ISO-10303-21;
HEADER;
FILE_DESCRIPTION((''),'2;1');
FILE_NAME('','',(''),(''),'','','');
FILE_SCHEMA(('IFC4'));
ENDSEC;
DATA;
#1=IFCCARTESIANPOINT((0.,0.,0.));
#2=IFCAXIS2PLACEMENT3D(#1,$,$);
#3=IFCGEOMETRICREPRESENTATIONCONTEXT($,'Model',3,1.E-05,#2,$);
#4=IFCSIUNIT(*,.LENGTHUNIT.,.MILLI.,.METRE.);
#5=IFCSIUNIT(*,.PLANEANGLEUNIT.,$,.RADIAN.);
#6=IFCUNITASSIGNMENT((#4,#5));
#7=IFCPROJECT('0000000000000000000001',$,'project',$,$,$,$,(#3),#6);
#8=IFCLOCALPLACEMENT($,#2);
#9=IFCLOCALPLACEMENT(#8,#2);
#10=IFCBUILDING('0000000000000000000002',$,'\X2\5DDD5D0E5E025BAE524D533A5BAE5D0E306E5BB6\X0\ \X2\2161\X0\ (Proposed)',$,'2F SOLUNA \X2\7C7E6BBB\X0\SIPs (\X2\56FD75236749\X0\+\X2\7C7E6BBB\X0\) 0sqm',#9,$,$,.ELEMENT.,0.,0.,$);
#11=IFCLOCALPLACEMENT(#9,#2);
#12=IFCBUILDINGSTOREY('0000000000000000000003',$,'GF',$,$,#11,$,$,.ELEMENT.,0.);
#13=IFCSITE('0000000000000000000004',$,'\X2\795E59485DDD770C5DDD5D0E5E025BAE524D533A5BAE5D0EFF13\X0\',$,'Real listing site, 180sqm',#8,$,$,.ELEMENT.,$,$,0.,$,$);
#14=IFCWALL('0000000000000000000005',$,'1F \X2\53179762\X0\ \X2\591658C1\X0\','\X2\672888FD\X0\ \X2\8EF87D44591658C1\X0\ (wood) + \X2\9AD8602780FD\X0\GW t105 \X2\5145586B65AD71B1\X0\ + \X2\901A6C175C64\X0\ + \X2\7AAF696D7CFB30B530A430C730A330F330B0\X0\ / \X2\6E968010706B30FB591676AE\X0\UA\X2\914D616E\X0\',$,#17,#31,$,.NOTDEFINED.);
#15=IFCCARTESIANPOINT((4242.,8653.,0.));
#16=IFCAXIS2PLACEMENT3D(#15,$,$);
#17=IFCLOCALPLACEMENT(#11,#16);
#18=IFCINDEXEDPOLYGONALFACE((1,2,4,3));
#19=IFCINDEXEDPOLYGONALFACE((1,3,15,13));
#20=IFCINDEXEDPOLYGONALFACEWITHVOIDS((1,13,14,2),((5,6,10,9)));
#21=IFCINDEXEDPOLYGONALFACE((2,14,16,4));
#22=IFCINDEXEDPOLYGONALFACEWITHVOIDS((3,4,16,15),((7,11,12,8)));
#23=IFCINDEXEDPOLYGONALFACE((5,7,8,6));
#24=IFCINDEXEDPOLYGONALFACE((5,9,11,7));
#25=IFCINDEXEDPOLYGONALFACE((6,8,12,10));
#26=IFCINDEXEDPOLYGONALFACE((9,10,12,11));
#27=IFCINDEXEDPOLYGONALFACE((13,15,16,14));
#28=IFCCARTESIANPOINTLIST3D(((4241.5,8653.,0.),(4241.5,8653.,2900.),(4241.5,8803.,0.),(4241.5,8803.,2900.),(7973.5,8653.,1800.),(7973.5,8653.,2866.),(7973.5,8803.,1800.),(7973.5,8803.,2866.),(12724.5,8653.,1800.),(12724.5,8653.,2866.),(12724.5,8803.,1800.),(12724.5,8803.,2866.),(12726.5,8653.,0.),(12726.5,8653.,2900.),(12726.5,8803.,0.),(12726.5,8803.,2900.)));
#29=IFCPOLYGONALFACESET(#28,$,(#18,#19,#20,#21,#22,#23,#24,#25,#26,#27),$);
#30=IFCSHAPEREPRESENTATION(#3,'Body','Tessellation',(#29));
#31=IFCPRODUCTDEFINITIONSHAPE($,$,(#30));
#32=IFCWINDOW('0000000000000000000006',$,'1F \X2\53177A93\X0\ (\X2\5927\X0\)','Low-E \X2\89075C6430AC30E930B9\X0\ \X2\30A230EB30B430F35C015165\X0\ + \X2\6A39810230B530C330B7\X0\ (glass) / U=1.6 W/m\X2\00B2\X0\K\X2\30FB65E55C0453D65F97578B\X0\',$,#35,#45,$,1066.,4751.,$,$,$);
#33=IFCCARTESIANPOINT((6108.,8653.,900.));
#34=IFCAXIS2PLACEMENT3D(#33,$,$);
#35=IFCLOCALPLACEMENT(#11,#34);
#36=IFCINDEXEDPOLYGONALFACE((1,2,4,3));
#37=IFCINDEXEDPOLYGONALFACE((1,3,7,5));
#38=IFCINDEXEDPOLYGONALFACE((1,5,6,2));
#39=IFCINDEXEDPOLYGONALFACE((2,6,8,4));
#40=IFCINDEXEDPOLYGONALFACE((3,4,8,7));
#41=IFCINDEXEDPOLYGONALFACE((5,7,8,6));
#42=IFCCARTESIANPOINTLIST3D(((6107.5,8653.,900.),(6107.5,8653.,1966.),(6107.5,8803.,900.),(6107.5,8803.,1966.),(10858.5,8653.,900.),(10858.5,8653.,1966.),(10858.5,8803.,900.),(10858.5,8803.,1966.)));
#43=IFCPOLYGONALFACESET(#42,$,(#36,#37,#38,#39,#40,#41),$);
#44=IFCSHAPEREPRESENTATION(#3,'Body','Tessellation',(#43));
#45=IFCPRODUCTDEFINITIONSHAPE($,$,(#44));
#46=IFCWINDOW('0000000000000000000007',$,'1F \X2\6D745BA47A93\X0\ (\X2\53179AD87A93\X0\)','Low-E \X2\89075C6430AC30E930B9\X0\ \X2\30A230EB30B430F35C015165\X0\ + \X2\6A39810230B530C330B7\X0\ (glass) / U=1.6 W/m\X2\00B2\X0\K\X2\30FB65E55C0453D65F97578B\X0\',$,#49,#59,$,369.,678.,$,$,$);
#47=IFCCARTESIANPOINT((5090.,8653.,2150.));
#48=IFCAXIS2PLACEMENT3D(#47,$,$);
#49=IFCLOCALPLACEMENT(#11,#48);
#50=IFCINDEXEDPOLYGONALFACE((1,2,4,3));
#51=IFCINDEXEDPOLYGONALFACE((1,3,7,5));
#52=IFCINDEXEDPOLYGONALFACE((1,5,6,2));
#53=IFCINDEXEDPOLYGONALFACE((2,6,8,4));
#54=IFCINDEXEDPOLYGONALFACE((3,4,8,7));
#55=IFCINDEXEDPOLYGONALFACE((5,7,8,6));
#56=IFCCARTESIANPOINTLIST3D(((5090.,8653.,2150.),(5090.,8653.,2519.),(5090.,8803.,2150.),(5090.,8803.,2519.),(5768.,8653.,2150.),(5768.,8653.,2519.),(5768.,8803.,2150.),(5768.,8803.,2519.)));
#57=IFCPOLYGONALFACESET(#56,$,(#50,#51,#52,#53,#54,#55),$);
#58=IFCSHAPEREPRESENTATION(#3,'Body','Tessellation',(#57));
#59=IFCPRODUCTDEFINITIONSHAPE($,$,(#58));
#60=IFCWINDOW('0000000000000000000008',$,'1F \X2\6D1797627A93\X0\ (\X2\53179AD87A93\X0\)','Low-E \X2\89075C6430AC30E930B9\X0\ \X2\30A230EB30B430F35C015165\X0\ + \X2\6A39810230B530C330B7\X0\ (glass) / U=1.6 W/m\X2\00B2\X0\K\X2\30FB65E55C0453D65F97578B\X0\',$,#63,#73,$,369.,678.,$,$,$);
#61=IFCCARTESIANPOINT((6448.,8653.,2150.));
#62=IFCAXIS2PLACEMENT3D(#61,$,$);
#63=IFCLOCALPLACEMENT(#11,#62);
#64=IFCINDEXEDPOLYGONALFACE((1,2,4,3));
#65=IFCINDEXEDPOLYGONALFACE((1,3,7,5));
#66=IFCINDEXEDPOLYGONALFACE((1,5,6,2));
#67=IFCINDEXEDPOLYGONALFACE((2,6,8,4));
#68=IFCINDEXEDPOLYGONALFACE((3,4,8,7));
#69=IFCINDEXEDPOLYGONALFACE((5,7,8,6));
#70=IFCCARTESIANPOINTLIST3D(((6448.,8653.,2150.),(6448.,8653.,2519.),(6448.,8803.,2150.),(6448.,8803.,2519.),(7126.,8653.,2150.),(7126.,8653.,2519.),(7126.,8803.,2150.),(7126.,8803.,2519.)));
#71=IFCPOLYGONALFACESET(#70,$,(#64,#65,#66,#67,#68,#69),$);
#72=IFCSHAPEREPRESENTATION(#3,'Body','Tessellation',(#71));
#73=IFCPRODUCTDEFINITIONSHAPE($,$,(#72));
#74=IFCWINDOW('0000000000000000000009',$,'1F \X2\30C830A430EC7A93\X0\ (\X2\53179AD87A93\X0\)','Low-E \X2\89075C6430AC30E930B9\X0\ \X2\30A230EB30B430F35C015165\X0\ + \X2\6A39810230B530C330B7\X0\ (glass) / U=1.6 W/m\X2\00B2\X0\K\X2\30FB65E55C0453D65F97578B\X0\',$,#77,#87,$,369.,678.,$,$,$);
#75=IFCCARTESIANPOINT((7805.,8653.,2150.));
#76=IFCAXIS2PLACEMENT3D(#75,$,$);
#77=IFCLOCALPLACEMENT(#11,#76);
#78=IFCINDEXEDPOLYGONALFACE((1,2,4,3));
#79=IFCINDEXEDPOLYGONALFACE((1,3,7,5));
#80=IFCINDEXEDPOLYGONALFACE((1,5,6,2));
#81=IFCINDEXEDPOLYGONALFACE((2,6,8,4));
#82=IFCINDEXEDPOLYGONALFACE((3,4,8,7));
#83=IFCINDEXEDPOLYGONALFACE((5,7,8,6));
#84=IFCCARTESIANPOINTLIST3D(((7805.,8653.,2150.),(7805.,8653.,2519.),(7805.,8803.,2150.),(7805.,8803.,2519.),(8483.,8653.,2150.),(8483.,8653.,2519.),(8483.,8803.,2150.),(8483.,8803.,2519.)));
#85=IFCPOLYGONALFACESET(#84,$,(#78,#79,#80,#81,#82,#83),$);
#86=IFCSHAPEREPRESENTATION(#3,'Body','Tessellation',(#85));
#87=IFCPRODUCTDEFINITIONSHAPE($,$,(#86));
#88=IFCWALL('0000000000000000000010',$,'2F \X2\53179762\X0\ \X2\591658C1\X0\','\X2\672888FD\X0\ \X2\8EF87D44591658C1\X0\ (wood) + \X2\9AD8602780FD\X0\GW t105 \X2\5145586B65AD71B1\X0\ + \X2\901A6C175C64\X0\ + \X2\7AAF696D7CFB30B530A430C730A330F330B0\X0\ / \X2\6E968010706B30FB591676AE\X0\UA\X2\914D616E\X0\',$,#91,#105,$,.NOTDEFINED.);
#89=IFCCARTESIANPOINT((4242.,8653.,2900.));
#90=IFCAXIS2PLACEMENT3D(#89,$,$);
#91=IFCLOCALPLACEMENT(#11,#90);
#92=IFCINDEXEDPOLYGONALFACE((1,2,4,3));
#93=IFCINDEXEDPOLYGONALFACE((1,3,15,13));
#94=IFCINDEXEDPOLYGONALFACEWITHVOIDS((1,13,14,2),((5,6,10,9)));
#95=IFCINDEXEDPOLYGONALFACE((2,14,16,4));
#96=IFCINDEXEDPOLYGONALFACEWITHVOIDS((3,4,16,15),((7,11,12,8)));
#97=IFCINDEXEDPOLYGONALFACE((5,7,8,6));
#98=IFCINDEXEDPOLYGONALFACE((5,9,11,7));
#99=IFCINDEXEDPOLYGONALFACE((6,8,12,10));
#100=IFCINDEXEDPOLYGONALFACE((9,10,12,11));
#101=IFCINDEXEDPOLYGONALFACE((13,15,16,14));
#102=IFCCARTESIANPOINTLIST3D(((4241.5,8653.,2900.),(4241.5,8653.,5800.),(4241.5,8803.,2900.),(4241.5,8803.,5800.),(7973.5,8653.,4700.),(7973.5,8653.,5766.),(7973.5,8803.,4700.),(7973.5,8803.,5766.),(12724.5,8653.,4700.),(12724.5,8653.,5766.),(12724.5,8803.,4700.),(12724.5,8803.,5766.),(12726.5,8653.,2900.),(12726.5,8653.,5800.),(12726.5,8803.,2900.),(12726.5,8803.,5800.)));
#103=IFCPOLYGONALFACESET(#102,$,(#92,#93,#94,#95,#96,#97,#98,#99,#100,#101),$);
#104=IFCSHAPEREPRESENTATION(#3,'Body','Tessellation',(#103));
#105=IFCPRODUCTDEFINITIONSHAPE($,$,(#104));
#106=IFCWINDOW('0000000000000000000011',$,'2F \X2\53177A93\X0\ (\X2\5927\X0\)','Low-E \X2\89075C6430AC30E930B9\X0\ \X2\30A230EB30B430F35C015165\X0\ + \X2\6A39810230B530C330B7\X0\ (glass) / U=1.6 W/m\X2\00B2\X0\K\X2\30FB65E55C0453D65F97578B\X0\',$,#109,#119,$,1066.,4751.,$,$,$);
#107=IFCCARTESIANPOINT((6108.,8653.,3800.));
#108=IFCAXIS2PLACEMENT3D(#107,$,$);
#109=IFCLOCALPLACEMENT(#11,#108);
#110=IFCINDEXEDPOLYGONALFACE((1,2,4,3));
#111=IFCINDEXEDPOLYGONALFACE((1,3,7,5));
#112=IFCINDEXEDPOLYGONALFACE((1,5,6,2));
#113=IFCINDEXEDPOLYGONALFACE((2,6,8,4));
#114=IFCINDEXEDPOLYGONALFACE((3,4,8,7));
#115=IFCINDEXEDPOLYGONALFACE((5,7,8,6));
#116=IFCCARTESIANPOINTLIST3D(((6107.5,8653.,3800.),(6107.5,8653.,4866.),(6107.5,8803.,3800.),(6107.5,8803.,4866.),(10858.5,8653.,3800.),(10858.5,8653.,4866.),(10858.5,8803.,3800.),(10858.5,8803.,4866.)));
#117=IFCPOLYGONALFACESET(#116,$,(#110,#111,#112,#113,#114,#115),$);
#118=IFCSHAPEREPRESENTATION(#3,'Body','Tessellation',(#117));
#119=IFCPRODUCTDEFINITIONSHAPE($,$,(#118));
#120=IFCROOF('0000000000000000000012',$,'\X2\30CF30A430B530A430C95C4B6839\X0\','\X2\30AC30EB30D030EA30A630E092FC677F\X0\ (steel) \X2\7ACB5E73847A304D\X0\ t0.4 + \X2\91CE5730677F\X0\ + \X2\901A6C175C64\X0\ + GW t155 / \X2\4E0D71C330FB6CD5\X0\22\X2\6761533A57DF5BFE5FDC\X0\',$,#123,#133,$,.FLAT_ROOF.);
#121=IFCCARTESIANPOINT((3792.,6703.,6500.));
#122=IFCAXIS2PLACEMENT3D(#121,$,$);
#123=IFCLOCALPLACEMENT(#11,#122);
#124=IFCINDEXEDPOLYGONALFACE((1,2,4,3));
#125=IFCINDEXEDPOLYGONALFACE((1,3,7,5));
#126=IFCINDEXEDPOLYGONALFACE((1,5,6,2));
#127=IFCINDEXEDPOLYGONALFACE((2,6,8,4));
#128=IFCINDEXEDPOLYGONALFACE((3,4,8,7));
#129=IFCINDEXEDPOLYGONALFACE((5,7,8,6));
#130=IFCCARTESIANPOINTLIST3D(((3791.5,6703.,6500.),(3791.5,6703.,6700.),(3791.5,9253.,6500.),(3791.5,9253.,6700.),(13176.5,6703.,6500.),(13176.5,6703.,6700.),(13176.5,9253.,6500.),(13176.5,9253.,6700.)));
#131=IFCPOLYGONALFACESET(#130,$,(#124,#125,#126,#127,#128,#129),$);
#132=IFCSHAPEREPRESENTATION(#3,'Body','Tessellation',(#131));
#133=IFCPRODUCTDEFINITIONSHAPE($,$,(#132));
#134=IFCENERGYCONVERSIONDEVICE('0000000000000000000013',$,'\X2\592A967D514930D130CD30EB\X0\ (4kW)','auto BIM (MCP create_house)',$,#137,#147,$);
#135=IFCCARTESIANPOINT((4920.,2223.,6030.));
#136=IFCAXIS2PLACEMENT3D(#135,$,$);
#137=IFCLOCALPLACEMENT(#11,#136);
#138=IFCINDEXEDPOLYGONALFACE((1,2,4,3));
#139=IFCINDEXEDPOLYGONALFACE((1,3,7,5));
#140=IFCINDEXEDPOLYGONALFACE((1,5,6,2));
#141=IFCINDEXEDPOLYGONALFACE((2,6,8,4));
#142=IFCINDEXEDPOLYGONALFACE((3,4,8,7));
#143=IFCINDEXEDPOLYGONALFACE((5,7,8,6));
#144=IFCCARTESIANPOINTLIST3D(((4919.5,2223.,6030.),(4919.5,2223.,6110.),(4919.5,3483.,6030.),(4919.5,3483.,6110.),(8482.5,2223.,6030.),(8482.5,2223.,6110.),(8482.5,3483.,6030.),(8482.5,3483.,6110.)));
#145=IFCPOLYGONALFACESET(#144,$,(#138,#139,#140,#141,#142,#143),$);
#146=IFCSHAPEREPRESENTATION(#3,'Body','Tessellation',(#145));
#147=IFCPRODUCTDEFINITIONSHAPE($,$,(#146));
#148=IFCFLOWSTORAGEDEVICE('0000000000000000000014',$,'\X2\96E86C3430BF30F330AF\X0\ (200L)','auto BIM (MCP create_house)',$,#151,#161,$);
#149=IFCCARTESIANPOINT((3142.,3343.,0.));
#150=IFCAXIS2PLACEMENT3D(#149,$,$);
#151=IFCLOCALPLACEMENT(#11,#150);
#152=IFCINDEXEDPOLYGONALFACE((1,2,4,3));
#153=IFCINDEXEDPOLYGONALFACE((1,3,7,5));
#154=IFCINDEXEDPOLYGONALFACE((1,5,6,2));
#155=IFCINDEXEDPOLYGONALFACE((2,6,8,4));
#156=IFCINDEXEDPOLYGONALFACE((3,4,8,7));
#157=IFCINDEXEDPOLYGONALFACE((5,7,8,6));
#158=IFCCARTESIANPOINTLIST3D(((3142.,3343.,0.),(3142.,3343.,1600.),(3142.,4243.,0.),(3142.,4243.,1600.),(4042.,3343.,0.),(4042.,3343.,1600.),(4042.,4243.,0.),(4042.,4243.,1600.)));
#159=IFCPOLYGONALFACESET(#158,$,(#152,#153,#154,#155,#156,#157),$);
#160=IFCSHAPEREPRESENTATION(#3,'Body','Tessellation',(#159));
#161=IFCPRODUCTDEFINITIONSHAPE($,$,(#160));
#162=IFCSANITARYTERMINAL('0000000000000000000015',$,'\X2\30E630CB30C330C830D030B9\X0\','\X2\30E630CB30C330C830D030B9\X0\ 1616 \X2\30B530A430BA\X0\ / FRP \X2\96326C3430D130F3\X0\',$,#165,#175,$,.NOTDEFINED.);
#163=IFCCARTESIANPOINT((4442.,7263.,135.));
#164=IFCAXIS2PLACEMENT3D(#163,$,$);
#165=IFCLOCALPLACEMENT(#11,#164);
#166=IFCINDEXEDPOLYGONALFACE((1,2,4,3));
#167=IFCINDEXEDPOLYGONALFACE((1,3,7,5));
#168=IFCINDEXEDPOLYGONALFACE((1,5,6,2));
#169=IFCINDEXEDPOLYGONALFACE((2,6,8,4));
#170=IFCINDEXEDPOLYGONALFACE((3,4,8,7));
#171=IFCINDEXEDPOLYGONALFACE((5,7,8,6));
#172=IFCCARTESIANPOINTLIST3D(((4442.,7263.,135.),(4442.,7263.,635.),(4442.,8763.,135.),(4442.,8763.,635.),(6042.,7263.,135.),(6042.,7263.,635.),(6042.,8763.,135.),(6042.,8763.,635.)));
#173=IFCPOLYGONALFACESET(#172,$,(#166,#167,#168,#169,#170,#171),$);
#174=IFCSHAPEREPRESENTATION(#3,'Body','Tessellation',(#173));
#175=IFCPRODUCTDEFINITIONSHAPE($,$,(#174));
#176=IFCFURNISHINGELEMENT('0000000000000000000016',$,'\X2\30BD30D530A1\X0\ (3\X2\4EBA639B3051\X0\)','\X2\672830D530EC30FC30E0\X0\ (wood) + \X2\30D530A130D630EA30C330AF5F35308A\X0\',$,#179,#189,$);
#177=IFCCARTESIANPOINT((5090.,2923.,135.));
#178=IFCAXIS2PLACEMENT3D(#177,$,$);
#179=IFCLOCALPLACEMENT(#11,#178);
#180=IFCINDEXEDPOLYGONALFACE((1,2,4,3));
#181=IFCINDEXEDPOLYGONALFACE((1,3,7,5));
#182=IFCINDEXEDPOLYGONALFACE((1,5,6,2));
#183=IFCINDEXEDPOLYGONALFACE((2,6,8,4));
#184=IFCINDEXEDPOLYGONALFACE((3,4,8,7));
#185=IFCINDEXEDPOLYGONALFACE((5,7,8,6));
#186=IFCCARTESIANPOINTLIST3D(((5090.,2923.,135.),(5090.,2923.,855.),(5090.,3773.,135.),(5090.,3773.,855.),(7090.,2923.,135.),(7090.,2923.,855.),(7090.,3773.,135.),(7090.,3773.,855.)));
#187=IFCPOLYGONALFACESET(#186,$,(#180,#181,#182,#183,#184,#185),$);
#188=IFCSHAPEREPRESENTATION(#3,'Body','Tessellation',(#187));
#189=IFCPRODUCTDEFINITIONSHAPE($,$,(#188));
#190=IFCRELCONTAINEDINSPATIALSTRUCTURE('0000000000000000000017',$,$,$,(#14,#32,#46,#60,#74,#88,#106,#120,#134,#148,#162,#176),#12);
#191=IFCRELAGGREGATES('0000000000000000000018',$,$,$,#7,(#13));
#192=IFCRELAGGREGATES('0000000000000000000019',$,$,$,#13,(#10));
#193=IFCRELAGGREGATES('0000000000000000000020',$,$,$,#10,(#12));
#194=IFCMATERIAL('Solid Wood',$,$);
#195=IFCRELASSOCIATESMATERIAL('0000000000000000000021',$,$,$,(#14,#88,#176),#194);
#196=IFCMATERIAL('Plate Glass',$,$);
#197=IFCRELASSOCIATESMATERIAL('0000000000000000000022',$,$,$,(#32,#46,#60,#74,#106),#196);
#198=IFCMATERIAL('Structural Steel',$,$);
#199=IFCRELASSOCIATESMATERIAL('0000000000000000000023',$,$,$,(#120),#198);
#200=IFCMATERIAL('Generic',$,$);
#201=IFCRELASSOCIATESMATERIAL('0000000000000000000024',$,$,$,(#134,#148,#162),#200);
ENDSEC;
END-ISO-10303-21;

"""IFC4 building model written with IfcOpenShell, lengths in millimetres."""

from ifc_helpers import new_model, si_unit, frame, frame_2d, origin, place, context, project, spatial, rectangle, extrude, material, element, fill, save


model = new_model("IFC4")

# Units and contexts
model_context = context("Model", 3, precision=1e-05, world=origin())
ifc_project = project(units=[si_unit("LENGTHUNIT", "METRE", prefix="MILLI"), si_unit("PLANEANGLEUNIT", "RADIAN")], contexts=[model_context])

# Site, building, storey
site_placement = place(None, origin())
site = spatial("IfcSite", under=ifc_project, at=site_placement, Name="神奈川県川崎市宮前区宮崎３", ObjectType="Real listing site, 180sqm", CompositionType="ELEMENT", RefElevation=0.0)
building_placement = place(site_placement, origin())
building = spatial("IfcBuilding", under=site, at=building_placement, Name="川崎市宮前区宮崎の家 Ⅱ (Proposed)", ObjectType="2F SOLUNA 籾殻SIPs (国産杉+籾殻) 0sqm", CompositionType="ELEMENT", ElevationOfRefHeight=0.0, ElevationOfTerrain=0.0)
storey_placement = place(building_placement, origin())
storey = spatial("IfcBuildingStorey", under=building, at=storey_placement, Name="GF", CompositionType="ELEMENT", Elevation=0.0)

# Wall, openings, windows
ifc_material_1 = material(Name="Solid Wood")
wall_1_placement = place(storey_placement, frame((4242.0, 8653.0, 0.0)))
wall_1 = element("IfcWall", 1, at=wall_1_placement, inside=storey, material=ifc_material_1, Name="1F 北面 外壁", Description="木製 軸組外壁 (wood) + 高性能GW t105 充填断熱 + 通気層 + 窯業系サイディング / 準耐火・外皮UA配慮", PredefinedType="NOTDEFINED", context=model_context, shape_type="SweptSolid", body=[
    extrude(rectangle(XDim=8485.0, YDim=150.0, at=frame_2d((4242.0, 75.0))), frame((4242.0, 8653.0, 0.0)), (0.0, 0.0, 1.0), 2900.0),
])
opening_1_placement = place(storey_placement, frame((6108.0, 8653.0, 900.0)))
opening_1 = element("IfcOpeningElement", 2, at=opening_1_placement, cuts=wall_1, PredefinedType="NOTDEFINED", context=model_context, shape_type="SweptSolid", body=[
    extrude(rectangle(XDim=4751.0, YDim=150.0, at=frame_2d((2375.0, 75.0))), frame((6108.0, 8653.0, 900.0)), (0.0, 0.0, 1.0), 1066.0),
])
opening_2_placement = place(storey_placement, frame((5090.0, 8653.0, 2150.0)))
opening_2 = element("IfcOpeningElement", 3, at=opening_2_placement, cuts=wall_1, PredefinedType="NOTDEFINED", context=model_context, shape_type="SweptSolid", body=[
    extrude(rectangle(XDim=678.0, YDim=150.0, at=frame_2d((339.0, 75.0))), frame((5090.0, 8653.0, 2150.0)), (0.0, 0.0, 1.0), 369.0),
])
opening_3_placement = place(storey_placement, frame((6448.0, 8653.0, 2150.0)))
opening_3 = element("IfcOpeningElement", 4, at=opening_3_placement, cuts=wall_1, PredefinedType="NOTDEFINED", context=model_context, shape_type="SweptSolid", body=[
    extrude(rectangle(XDim=678.0, YDim=150.0, at=frame_2d((339.0, 75.0))), frame((6448.0, 8653.0, 2150.0)), (0.0, 0.0, 1.0), 369.0),
])
opening_4_placement = place(storey_placement, frame((7805.0, 8653.0, 2150.0)))
opening_4 = element("IfcOpeningElement", 5, at=opening_4_placement, cuts=wall_1, PredefinedType="NOTDEFINED", context=model_context, shape_type="SweptSolid", body=[
    extrude(rectangle(XDim=678.0, YDim=150.0, at=frame_2d((339.0, 75.0))), frame((7805.0, 8653.0, 2150.0)), (0.0, 0.0, 1.0), 369.0),
])
ifc_material_2 = material(Name="Plate Glass")
window_1_placement = place(storey_placement, frame((6108.0, 8653.0, 900.0)))
window_1 = element("IfcWindow", 6, at=window_1_placement, inside=storey, material=ifc_material_2, Name="1F 北窓 (大)", Description="Low-E 複層ガラス アルゴン封入 + 樹脂サッシ (glass) / U=1.6 W/m²K・日射取得型", OverallHeight=1066.0, OverallWidth=4751.0, context=model_context, shape_type="SweptSolid", body=[
    extrude(rectangle(XDim=4751.0, YDim=150.0, at=frame_2d((2375.0, 75.0))), frame((6108.0, 8653.0, 900.0)), (0.0, 0.0, 1.0), 1066.0),
])
fill(opening_1, window_1)
window_2_placement = place(storey_placement, frame((5090.0, 8653.0, 2150.0)))
window_2 = element("IfcWindow", 7, at=window_2_placement, inside=storey, material=ifc_material_2, Name="1F 浴室窓 (北高窓)", Description="Low-E 複層ガラス アルゴン封入 + 樹脂サッシ (glass) / U=1.6 W/m²K・日射取得型", OverallHeight=369.0, OverallWidth=678.0, context=model_context, shape_type="SweptSolid", body=[
    extrude(rectangle(XDim=678.0, YDim=150.0, at=frame_2d((339.0, 75.0))), frame((5090.0, 8653.0, 2150.0)), (0.0, 0.0, 1.0), 369.0),
])
fill(opening_2, window_2)
window_3_placement = place(storey_placement, frame((6448.0, 8653.0, 2150.0)))
window_3 = element("IfcWindow", 8, at=window_3_placement, inside=storey, material=ifc_material_2, Name="1F 洗面窓 (北高窓)", Description="Low-E 複層ガラス アルゴン封入 + 樹脂サッシ (glass) / U=1.6 W/m²K・日射取得型", OverallHeight=369.0, OverallWidth=678.0, context=model_context, shape_type="SweptSolid", body=[
    extrude(rectangle(XDim=678.0, YDim=150.0, at=frame_2d((339.0, 75.0))), frame((6448.0, 8653.0, 2150.0)), (0.0, 0.0, 1.0), 369.0),
])
fill(opening_3, window_3)
window_4_placement = place(storey_placement, frame((7805.0, 8653.0, 2150.0)))
window_4 = element("IfcWindow", 9, at=window_4_placement, inside=storey, material=ifc_material_2, Name="1F トイレ窓 (北高窓)", Description="Low-E 複層ガラス アルゴン封入 + 樹脂サッシ (glass) / U=1.6 W/m²K・日射取得型", OverallHeight=369.0, OverallWidth=678.0, context=model_context, shape_type="SweptSolid", body=[
    extrude(rectangle(XDim=678.0, YDim=150.0, at=frame_2d((339.0, 75.0))), frame((7805.0, 8653.0, 2150.0)), (0.0, 0.0, 1.0), 369.0),
])
fill(opening_4, window_4)

# Wall, opening, window
wall_2_placement = place(storey_placement, frame((4242.0, 8653.0, 2900.0)))
wall_2 = element("IfcWall", 10, at=wall_2_placement, inside=storey, material=ifc_material_1, Name="2F 北面 外壁", Description="木製 軸組外壁 (wood) + 高性能GW t105 充填断熱 + 通気層 + 窯業系サイディング / 準耐火・外皮UA配慮", PredefinedType="NOTDEFINED", context=model_context, shape_type="SweptSolid", body=[
    extrude(rectangle(XDim=8485.0, YDim=150.0, at=frame_2d((4242.0, 75.0))), frame((4242.0, 8653.0, 2900.0)), (0.0, 0.0, 1.0), 2900.0),
])
opening_5_placement = place(storey_placement, frame((6108.0, 8653.0, 3800.0)))
opening_5 = element("IfcOpeningElement", 11, at=opening_5_placement, cuts=wall_2, PredefinedType="NOTDEFINED", context=model_context, shape_type="SweptSolid", body=[
    extrude(rectangle(XDim=4751.0, YDim=150.0, at=frame_2d((2375.0, 75.0))), frame((6108.0, 8653.0, 3800.0)), (0.0, 0.0, 1.0), 1066.0),
])
window_5_placement = place(storey_placement, frame((6108.0, 8653.0, 3800.0)))
window_5 = element("IfcWindow", 12, at=window_5_placement, inside=storey, material=ifc_material_2, Name="2F 北窓 (大)", Description="Low-E 複層ガラス アルゴン封入 + 樹脂サッシ (glass) / U=1.6 W/m²K・日射取得型", OverallHeight=1066.0, OverallWidth=4751.0, context=model_context, shape_type="SweptSolid", body=[
    extrude(rectangle(XDim=4751.0, YDim=150.0, at=frame_2d((2375.0, 75.0))), frame((6108.0, 8653.0, 3800.0)), (0.0, 0.0, 1.0), 1066.0),
])
fill(opening_5, window_5)

# Roof
ifc_material_3 = material(Name="Structural Steel")
roof_placement = place(storey_placement, frame((3792.0, 6703.0, 6500.0)))
element("IfcRoof", 13, at=roof_placement, inside=storey, material=ifc_material_3, Name="ハイサイド屋根", Description="ガルバリウム鋼板 (steel) 立平葺き t0.4 + 野地板 + 通気層 + GW t155 / 不燃・法22条区域対応", PredefinedType="FLAT_ROOF", context=model_context, shape_type="SweptSolid", body=[
    extrude(rectangle(XDim=9385.0, YDim=2550.0, at=frame_2d((4692.0, 1275.0))), frame((3792.0, 6703.0, 6500.0)), (0.0, 0.0, 1.0), 200.0),
])

# Energy conversion device
ifc_material_4 = material(Name="Generic")
energy_conversion_device_placement = place(storey_placement, frame((4920.0, 2223.0, 6030.0)))
element("IfcEnergyConversionDevice", 14, at=energy_conversion_device_placement, inside=storey, material=ifc_material_4, Name="太陽光パネル (4kW)", Description="auto BIM (MCP create_house)", context=model_context, shape_type="SweptSolid", body=[
    extrude(rectangle(XDim=3563.0, YDim=1260.0, at=frame_2d((1781.0, 630.0))), frame((4920.0, 2223.0, 6030.0)), (0.0, 0.0, 1.0), 80.0),
])

# Flow storage device
flow_storage_device_placement = place(storey_placement, frame((3142.0, 3343.0, 0.0)))
element("IfcFlowStorageDevice", 15, at=flow_storage_device_placement, inside=storey, material=ifc_material_4, Name="雨水タンク (200L)", Description="auto BIM (MCP create_house)", context=model_context, shape_type="SweptSolid", body=[
    extrude(rectangle(XDim=900.0, YDim=900.0, at=frame_2d((450.0, 450.0))), frame((3142.0, 3343.0, 0.0)), (0.0, 0.0, 1.0), 1600.0),
])

# Sanitary terminal
sanitary_terminal_placement = place(storey_placement, frame((4442.0, 7263.0, 135.0)))
element("IfcSanitaryTerminal", 16, at=sanitary_terminal_placement, inside=storey, material=ifc_material_4, Name="ユニットバス", Description="ユニットバス 1616 サイズ / FRP 防水パン", PredefinedType="NOTDEFINED", context=model_context, shape_type="SweptSolid", body=[
    extrude(rectangle(XDim=1600.0, YDim=1500.0, at=frame_2d((800.0, 750.0))), frame((4442.0, 7263.0, 135.0)), (0.0, 0.0, 1.0), 500.0),
])

# Furnishing element
furnishing_1_placement = place(storey_placement, frame((5090.0, 2923.0, 135.0)))
element("IfcFurnishingElement", 17, at=furnishing_1_placement, inside=storey, material=ifc_material_1, Name="ソファ (3人掛け)", Description="木フレーム (wood) + ファブリック張り", context=model_context, shape_type="SweptSolid", body=[
    extrude(rectangle(XDim=2000.0, YDim=850.0, at=frame_2d((1000.0, 425.0))), frame((5090.0, 2923.0, 135.0)), (0.0, 0.0, 1.0), 720.0),
])

save(model, "model.ifc")
